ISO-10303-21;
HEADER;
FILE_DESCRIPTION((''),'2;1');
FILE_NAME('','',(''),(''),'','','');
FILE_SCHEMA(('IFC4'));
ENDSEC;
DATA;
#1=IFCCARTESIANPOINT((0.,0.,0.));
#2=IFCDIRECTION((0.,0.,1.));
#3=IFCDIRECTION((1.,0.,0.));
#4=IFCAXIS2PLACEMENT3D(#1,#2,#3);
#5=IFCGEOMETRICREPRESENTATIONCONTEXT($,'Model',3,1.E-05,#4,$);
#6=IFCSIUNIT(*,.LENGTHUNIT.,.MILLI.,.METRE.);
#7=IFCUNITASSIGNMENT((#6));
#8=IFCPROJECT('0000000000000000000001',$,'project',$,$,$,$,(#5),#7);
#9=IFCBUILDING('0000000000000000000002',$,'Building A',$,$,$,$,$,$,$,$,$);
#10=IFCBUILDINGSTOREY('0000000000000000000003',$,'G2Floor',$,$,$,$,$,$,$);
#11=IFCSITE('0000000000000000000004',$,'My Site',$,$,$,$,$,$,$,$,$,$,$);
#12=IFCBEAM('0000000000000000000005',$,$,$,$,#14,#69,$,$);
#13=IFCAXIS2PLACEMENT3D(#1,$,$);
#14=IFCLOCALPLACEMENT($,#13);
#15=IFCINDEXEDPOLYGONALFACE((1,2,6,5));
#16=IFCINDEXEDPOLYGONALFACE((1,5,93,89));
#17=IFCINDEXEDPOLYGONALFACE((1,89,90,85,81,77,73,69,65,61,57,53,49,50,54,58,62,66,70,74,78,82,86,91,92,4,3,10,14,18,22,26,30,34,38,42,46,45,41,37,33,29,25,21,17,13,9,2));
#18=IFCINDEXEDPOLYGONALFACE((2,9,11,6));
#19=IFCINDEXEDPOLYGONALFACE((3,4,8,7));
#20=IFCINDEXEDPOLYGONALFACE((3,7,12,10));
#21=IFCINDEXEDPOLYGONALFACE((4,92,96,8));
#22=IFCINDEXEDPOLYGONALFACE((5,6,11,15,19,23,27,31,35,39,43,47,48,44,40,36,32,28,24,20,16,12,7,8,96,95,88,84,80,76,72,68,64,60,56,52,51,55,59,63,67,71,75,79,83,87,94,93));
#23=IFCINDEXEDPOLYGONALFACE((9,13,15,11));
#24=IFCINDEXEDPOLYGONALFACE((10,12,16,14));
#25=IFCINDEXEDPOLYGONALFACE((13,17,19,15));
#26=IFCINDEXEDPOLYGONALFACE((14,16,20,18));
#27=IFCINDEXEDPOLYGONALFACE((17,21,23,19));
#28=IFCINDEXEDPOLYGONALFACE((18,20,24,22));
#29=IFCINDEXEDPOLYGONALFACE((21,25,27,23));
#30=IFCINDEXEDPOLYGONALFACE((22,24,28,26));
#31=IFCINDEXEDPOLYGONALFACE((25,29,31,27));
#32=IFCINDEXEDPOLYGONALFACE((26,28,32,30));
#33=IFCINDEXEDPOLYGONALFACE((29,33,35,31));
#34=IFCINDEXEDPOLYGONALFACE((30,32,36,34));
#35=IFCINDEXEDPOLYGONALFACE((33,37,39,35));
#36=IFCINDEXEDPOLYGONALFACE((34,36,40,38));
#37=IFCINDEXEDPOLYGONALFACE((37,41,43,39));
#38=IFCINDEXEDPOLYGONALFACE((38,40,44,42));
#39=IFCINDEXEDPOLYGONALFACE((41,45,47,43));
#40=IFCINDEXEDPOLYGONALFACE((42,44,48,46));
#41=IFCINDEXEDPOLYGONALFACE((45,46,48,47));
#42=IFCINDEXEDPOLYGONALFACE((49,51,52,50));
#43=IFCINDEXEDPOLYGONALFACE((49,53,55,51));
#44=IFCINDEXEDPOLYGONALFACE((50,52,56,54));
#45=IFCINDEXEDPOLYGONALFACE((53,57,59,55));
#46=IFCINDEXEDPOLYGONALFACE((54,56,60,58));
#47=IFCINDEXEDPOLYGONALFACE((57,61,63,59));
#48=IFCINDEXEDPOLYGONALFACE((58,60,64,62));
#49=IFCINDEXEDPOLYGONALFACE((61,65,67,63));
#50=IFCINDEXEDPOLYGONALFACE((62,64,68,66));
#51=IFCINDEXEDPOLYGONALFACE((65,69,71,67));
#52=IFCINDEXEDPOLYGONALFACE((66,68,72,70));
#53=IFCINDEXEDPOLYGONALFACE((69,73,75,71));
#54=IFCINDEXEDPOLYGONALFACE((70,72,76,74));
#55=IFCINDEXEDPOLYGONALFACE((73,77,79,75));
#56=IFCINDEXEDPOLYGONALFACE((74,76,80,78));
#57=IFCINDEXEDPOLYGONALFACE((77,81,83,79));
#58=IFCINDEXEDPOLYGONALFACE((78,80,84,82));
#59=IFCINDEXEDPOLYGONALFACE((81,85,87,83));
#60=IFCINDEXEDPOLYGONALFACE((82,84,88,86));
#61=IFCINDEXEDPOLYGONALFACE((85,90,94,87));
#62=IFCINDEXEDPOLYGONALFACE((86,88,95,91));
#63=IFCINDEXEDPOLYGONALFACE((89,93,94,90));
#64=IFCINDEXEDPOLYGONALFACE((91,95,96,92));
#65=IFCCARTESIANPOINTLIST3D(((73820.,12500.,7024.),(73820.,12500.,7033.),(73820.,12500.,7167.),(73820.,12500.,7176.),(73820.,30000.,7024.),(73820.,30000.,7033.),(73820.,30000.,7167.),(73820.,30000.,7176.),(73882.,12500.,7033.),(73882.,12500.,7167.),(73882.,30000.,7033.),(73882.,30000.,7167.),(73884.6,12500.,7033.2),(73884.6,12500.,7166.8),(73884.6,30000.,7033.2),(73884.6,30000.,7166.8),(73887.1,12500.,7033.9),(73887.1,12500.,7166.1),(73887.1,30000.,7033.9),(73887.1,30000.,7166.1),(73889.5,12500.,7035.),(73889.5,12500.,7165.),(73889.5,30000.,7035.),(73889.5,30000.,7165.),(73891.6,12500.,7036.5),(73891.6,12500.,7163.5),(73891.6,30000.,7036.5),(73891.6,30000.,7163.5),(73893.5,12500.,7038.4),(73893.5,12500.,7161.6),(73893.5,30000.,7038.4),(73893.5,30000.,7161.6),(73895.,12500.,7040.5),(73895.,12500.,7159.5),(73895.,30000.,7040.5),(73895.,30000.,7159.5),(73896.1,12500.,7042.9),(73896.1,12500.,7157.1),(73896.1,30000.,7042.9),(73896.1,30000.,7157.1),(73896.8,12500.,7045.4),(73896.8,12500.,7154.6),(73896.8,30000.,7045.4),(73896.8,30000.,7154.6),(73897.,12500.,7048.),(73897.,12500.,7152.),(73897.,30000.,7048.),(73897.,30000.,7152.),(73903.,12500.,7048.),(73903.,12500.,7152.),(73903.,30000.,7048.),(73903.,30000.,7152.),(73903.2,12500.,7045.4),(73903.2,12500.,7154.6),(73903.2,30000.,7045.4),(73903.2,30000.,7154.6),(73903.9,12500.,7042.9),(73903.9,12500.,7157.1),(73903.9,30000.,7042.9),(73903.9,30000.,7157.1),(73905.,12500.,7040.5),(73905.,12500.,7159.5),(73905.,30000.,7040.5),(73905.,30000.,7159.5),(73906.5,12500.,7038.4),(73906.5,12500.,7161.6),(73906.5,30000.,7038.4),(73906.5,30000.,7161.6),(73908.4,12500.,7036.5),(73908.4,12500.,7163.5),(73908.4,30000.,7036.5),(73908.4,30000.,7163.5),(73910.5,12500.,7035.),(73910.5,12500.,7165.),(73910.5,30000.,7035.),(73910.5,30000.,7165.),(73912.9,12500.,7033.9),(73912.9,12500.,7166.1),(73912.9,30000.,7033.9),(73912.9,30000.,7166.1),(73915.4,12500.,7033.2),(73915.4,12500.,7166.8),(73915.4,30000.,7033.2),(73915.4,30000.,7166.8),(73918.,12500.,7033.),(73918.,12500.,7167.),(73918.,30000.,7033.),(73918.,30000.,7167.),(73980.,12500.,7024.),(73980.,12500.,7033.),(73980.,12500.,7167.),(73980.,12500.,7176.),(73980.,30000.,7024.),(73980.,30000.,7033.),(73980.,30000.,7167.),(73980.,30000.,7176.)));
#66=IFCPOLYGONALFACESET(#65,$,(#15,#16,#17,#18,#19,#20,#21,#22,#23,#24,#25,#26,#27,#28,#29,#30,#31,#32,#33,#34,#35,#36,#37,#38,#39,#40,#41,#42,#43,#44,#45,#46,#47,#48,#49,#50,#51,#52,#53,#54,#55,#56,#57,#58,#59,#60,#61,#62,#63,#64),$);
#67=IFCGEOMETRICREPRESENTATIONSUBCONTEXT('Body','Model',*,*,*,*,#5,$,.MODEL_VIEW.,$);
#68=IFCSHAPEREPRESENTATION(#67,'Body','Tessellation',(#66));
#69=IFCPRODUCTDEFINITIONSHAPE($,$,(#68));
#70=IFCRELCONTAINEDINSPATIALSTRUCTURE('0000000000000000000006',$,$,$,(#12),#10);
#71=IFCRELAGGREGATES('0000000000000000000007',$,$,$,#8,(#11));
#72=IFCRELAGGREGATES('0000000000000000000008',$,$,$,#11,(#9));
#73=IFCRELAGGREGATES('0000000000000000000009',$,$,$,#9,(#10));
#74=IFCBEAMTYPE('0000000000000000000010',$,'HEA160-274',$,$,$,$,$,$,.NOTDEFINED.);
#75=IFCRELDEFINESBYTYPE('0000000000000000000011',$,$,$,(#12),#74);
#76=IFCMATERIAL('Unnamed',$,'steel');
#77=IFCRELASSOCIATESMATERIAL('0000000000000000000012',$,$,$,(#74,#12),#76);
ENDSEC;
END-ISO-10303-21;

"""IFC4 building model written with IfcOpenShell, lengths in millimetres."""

from ifc_helpers import new_model, si_unit, frame, origin_with_axes, place, context, subcontext, project, spatial, polyline, outline, extrude, material, material_profile, profile_set, profile_usage, type_object, element, save


model = new_model("IFC4")

# Units and contexts
model_context = context("Model", 3, precision=1e-05, world=origin_with_axes())
body_context = subcontext(model_context, "Body", "Model", "MODEL_VIEW")
ifc_project = project(units=[si_unit("LENGTHUNIT", "METRE", prefix="MILLI")], contexts=[model_context])

# Site, building, storey
site = spatial("IfcSite", under=ifc_project, Name="My Site")
building = spatial("IfcBuilding", under=site, Name="Building A")
storey = spatial("IfcBuildingStorey", under=building, Name="G2Floor")

# Beam
ifc_material_1 = material(Name="Unnamed", Category="steel")
ifc_material_profile_1 = material_profile(ifc_material_1, outline(polyline([(80.0, -76.0), (80.0, -67.0), (80.0, -67.0), (18.0, -67.0), (18.0, -67.0), (15.4, -66.8), (15.4, -66.8), (12.9, -66.1), (12.9, -66.1), (10.5, -65.0), (10.5, -65.0), (8.4, -63.5), (8.4, -63.5), (6.5, -61.6), (6.5, -61.6), (5.0, -59.5), (5.0, -59.5), (3.9, -57.1), (3.9, -57.1), (3.2, -54.6), (3.2, -54.6), (3.0, -52.0), (3.0, -52.0), (3.0, 52.0), (3.0, 52.0), (3.2, 54.6), (3.2, 54.6), (3.9, 57.1), (3.9, 57.1), (5.0, 59.5), (5.0, 59.5), (6.5, 61.6), (6.5, 61.6), (8.4, 63.5), (8.4, 63.5), (10.5, 65.0), (10.5, 65.0), (12.9, 66.1), (12.9, 66.1), (15.4, 66.8), (15.4, 66.8), (18.0, 67.0), (18.0, 67.0), (80.0, 67.0), (80.0, 67.0), (80.0, 76.0), (80.0, 76.0), (-80.0, 76.0), (-80.0, 76.0), (-80.0, 67.0), (-80.0, 67.0), (-18.0, 67.0), (-18.0, 67.0), (-15.4, 66.8), (-15.4, 66.8), (-12.9, 66.1), (-12.9, 66.1), (-10.5, 65.0), (-10.5, 65.0), (-8.4, 63.5), (-8.4, 63.5), (-6.5, 61.6), (-6.5, 61.6), (-5.0, 59.5), (-5.0, 59.5), (-3.9, 57.1), (-3.9, 57.1), (-3.2, 54.6), (-3.2, 54.6), (-3.0, 52.0), (-3.0, 52.0), (-3.0, -52.0), (-3.0, -52.0), (-3.2, -54.6), (-3.2, -54.6), (-3.9, -57.1), (-3.9, -57.1), (-5.0, -59.5), (-5.0, -59.5), (-6.5, -61.6), (-6.5, -61.6), (-8.4, -63.5), (-8.4, -63.5), (-10.5, -65.0), (-10.5, -65.0), (-12.9, -66.1), (-12.9, -66.1), (-15.4, -66.8), (-15.4, -66.8), (-18.0, -67.0), (-18.0, -67.0), (-80.0, -67.0), (-80.0, -67.0), (-80.0, -76.0), (-80.0, -76.0), (80.0, -76.0)])))
ifc_profile_set_1 = profile_set([ifc_material_profile_1], Name="HEA160-274")
ifc_profile_usage_1 = profile_usage(ifc_profile_set_1)
beam_type_1 = type_object("IfcBeamType", Name="HEA160-274", PredefinedType="NOTDEFINED", material=ifc_profile_set_1)
beam_1_placement = place(None, frame((73900.0, 12500.0, 7100.0), z_axis=(0.0, 1.0, 0.0), x_axis=(1.0, 0.0, 0.0)))
element("IfcBeam", 1, at=beam_1_placement, inside=storey, type_object=beam_type_1, material=ifc_profile_usage_1, context=body_context, shape_type="SweptSolid", body=[
    extrude(outline(polyline([(80.0, -76.0), (80.0, -67.0), (80.0, -67.0), (18.0, -67.0), (18.0, -67.0), (15.4, -66.8), (15.4, -66.8), (12.9, -66.1), (12.9, -66.1), (10.5, -65.0), (10.5, -65.0), (8.4, -63.5), (8.4, -63.5), (6.5, -61.6), (6.5, -61.6), (5.0, -59.5), (5.0, -59.5), (3.9, -57.1), (3.9, -57.1), (3.2, -54.6), (3.2, -54.6), (3.0, -52.0), (3.0, -52.0), (3.0, 52.0), (3.0, 52.0), (3.2, 54.6), (3.2, 54.6), (3.9, 57.1), (3.9, 57.1), (5.0, 59.5), (5.0, 59.5), (6.5, 61.6), (6.5, 61.6), (8.4, 63.5), (8.4, 63.5), (10.5, 65.0), (10.5, 65.0), (12.9, 66.1), (12.9, 66.1), (15.4, 66.8), (15.4, 66.8), (18.0, 67.0), (18.0, 67.0), (80.0, 67.0), (80.0, 67.0), (80.0, 76.0), (80.0, 76.0), (-80.0, 76.0), (-80.0, 76.0), (-80.0, 67.0), (-80.0, 67.0), (-18.0, 67.0), (-18.0, 67.0), (-15.4, 66.8), (-15.4, 66.8), (-12.9, 66.1), (-12.9, 66.1), (-10.5, 65.0), (-10.5, 65.0), (-8.4, 63.5), (-8.4, 63.5), (-6.5, 61.6), (-6.5, 61.6), (-5.0, 59.5), (-5.0, 59.5), (-3.9, 57.1), (-3.9, 57.1), (-3.2, 54.6), (-3.2, 54.6), (-3.0, 52.0), (-3.0, 52.0), (-3.0, -52.0), (-3.0, -52.0), (-3.2, -54.6), (-3.2, -54.6), (-3.9, -57.1), (-3.9, -57.1), (-5.0, -59.5), (-5.0, -59.5), (-6.5, -61.6), (-6.5, -61.6), (-8.4, -63.5), (-8.4, -63.5), (-10.5, -65.0), (-10.5, -65.0), (-12.9, -66.1), (-12.9, -66.1), (-15.4, -66.8), (-15.4, -66.8), (-18.0, -67.0), (-18.0, -67.0), (-80.0, -67.0), (-80.0, -67.0), (-80.0, -76.0), (-80.0, -76.0), (80.0, -76.0)])), origin_with_axes(), (0.0, 0.0, 1.0), 17500.0),
])

save(model, "model.ifc")
